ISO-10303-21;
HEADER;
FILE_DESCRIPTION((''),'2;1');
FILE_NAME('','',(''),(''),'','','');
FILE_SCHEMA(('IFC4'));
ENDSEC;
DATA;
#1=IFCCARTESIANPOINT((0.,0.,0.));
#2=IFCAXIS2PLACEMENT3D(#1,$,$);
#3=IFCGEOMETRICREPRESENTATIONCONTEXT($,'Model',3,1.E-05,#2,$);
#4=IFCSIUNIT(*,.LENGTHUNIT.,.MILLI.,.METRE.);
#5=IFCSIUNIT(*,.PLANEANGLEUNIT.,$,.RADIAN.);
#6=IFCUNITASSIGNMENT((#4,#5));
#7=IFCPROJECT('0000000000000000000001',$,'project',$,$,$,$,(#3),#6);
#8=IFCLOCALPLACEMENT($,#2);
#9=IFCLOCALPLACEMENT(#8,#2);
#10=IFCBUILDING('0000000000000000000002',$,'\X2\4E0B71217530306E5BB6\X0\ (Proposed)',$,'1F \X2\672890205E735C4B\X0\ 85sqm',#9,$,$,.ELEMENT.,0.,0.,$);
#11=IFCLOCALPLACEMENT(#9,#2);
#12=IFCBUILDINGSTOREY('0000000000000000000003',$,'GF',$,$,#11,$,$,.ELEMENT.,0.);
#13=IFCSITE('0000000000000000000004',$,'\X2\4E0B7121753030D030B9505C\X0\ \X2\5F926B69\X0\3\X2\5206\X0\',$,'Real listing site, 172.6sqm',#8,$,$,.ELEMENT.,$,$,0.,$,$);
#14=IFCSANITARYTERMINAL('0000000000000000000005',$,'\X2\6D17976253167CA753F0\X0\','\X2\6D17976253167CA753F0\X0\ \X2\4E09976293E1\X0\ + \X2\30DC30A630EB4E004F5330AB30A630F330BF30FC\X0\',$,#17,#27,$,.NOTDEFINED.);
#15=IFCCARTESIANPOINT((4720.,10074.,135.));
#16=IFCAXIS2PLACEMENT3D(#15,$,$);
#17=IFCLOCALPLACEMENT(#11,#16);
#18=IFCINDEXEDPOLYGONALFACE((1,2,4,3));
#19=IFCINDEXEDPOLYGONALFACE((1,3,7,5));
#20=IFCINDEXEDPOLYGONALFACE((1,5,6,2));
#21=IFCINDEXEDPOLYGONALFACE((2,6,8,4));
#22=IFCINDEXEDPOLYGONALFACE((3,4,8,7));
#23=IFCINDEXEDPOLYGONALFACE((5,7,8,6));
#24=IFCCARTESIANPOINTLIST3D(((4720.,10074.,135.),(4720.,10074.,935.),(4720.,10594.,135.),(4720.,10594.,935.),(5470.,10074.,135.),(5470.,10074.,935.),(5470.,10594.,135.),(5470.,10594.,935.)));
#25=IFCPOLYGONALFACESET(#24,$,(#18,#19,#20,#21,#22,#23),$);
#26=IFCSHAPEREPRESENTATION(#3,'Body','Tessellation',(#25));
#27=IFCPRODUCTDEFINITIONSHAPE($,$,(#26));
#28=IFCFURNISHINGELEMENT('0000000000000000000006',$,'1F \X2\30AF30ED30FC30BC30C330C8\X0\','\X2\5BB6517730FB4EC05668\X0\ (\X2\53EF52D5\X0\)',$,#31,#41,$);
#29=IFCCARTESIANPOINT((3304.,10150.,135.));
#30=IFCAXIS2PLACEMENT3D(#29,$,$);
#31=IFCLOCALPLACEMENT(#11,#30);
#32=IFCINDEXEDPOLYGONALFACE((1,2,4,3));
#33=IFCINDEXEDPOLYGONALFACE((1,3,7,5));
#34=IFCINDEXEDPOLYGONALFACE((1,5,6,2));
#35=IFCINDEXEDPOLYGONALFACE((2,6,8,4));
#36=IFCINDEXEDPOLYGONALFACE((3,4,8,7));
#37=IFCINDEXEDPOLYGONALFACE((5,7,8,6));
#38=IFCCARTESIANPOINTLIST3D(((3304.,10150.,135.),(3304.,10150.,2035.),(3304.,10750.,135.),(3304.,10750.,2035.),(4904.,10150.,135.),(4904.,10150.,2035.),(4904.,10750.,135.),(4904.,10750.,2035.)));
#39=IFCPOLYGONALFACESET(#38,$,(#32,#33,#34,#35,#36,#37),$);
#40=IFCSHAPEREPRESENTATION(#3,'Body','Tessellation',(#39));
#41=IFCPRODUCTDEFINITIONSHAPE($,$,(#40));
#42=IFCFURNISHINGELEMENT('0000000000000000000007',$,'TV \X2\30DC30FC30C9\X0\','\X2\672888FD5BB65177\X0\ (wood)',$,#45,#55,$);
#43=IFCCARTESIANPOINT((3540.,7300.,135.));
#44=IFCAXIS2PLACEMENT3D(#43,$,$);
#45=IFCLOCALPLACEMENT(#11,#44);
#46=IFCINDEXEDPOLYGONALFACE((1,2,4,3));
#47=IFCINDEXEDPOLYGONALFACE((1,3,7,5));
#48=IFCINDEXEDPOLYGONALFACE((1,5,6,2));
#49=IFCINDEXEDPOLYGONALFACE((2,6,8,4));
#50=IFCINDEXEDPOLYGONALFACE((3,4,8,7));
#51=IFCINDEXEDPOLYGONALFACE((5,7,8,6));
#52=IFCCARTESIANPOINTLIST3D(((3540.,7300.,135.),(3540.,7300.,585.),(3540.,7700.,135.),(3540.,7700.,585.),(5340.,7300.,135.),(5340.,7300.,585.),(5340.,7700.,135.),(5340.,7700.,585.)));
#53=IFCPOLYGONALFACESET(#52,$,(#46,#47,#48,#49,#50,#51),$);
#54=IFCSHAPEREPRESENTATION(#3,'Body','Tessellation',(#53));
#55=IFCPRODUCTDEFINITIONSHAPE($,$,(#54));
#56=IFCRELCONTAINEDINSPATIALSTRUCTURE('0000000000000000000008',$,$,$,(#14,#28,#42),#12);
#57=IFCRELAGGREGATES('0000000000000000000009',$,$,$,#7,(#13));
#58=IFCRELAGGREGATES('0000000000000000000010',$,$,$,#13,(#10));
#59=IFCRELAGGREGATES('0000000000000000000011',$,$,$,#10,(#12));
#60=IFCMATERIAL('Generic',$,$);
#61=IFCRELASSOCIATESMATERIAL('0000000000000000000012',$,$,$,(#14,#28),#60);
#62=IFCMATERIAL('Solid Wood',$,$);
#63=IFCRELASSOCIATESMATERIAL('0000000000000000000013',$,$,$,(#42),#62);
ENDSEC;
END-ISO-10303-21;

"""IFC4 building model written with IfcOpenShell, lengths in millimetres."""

from ifc_helpers import new_model, si_unit, frame, frame_2d, origin, place, context, project, spatial, rectangle, extrude, material, element, save


model = new_model("IFC4")

# Units and contexts
model_context = context("Model", 3, precision=1e-05, world=origin())
ifc_project = project(units=[si_unit("LENGTHUNIT", "METRE", prefix="MILLI"), si_unit("PLANEANGLEUNIT", "RADIAN")], contexts=[model_context])

# Site, building, storey
site_placement = place(None, origin())
site = spatial("IfcSite", under=ifc_project, at=site_placement, Name="下無田バス停 徒歩3分", ObjectType="Real listing site, 172.6sqm", CompositionType="ELEMENT", RefElevation=0.0)
building_placement = place(site_placement, origin())
building = spatial("IfcBuilding", under=site, at=building_placement, Name="下無田の家 (Proposed)", ObjectType="1F 木造平屋 85sqm", CompositionType="ELEMENT", ElevationOfRefHeight=0.0, ElevationOfTerrain=0.0)
storey_placement = place(building_placement, origin())
storey = spatial("IfcBuildingStorey", under=building, at=storey_placement, Name="GF", CompositionType="ELEMENT", Elevation=0.0)

# Shared definitions
ifc_material_1 = material(Name="Solid Wood")

# Shared definitions
ifc_material_2 = material(Name="Generic")

# Sanitary terminal
sanitary_terminal_1_placement = place(storey_placement, frame((4720.0, 10074.0, 135.0)))
element("IfcSanitaryTerminal", 1, at=sanitary_terminal_1_placement, inside=storey, material=ifc_material_2, Name="洗面化粧台", Description="洗面化粧台 三面鏡 + ボウル一体カウンター", PredefinedType="NOTDEFINED", context=model_context, shape_type="SweptSolid", body=[
    extrude(rectangle(XDim=750.0, YDim=520.0, at=frame_2d((375.0, 260.0))), frame((4720.0, 10074.0, 135.0)), (0.0, 0.0, 1.0), 800.0),
])

# Furnishing elements
furnishing_1_placement = place(storey_placement, frame((3304.0, 10150.0, 135.0)))
element("IfcFurnishingElement", 2, at=furnishing_1_placement, inside=storey, material=ifc_material_2, Name="1F クローゼット", Description="家具・什器 (可動)", context=model_context, shape_type="SweptSolid", body=[
    extrude(rectangle(XDim=1600.0, YDim=600.0, at=frame_2d((800.0, 300.0))), frame((3304.0, 10150.0, 135.0)), (0.0, 0.0, 1.0), 1900.0),
])
furnishing_2_placement = place(storey_placement, frame((3540.0, 7300.0, 135.0)))
element("IfcFurnishingElement", 3, at=furnishing_2_placement, inside=storey, material=ifc_material_1, Name="TV ボード", Description="木製家具 (wood)", context=model_context, shape_type="SweptSolid", body=[
    extrude(rectangle(XDim=1800.0, YDim=400.0, at=frame_2d((900.0, 200.0))), frame((3540.0, 7300.0, 135.0)), (0.0, 0.0, 1.0), 450.0),
])

save(model, "model.ifc")
